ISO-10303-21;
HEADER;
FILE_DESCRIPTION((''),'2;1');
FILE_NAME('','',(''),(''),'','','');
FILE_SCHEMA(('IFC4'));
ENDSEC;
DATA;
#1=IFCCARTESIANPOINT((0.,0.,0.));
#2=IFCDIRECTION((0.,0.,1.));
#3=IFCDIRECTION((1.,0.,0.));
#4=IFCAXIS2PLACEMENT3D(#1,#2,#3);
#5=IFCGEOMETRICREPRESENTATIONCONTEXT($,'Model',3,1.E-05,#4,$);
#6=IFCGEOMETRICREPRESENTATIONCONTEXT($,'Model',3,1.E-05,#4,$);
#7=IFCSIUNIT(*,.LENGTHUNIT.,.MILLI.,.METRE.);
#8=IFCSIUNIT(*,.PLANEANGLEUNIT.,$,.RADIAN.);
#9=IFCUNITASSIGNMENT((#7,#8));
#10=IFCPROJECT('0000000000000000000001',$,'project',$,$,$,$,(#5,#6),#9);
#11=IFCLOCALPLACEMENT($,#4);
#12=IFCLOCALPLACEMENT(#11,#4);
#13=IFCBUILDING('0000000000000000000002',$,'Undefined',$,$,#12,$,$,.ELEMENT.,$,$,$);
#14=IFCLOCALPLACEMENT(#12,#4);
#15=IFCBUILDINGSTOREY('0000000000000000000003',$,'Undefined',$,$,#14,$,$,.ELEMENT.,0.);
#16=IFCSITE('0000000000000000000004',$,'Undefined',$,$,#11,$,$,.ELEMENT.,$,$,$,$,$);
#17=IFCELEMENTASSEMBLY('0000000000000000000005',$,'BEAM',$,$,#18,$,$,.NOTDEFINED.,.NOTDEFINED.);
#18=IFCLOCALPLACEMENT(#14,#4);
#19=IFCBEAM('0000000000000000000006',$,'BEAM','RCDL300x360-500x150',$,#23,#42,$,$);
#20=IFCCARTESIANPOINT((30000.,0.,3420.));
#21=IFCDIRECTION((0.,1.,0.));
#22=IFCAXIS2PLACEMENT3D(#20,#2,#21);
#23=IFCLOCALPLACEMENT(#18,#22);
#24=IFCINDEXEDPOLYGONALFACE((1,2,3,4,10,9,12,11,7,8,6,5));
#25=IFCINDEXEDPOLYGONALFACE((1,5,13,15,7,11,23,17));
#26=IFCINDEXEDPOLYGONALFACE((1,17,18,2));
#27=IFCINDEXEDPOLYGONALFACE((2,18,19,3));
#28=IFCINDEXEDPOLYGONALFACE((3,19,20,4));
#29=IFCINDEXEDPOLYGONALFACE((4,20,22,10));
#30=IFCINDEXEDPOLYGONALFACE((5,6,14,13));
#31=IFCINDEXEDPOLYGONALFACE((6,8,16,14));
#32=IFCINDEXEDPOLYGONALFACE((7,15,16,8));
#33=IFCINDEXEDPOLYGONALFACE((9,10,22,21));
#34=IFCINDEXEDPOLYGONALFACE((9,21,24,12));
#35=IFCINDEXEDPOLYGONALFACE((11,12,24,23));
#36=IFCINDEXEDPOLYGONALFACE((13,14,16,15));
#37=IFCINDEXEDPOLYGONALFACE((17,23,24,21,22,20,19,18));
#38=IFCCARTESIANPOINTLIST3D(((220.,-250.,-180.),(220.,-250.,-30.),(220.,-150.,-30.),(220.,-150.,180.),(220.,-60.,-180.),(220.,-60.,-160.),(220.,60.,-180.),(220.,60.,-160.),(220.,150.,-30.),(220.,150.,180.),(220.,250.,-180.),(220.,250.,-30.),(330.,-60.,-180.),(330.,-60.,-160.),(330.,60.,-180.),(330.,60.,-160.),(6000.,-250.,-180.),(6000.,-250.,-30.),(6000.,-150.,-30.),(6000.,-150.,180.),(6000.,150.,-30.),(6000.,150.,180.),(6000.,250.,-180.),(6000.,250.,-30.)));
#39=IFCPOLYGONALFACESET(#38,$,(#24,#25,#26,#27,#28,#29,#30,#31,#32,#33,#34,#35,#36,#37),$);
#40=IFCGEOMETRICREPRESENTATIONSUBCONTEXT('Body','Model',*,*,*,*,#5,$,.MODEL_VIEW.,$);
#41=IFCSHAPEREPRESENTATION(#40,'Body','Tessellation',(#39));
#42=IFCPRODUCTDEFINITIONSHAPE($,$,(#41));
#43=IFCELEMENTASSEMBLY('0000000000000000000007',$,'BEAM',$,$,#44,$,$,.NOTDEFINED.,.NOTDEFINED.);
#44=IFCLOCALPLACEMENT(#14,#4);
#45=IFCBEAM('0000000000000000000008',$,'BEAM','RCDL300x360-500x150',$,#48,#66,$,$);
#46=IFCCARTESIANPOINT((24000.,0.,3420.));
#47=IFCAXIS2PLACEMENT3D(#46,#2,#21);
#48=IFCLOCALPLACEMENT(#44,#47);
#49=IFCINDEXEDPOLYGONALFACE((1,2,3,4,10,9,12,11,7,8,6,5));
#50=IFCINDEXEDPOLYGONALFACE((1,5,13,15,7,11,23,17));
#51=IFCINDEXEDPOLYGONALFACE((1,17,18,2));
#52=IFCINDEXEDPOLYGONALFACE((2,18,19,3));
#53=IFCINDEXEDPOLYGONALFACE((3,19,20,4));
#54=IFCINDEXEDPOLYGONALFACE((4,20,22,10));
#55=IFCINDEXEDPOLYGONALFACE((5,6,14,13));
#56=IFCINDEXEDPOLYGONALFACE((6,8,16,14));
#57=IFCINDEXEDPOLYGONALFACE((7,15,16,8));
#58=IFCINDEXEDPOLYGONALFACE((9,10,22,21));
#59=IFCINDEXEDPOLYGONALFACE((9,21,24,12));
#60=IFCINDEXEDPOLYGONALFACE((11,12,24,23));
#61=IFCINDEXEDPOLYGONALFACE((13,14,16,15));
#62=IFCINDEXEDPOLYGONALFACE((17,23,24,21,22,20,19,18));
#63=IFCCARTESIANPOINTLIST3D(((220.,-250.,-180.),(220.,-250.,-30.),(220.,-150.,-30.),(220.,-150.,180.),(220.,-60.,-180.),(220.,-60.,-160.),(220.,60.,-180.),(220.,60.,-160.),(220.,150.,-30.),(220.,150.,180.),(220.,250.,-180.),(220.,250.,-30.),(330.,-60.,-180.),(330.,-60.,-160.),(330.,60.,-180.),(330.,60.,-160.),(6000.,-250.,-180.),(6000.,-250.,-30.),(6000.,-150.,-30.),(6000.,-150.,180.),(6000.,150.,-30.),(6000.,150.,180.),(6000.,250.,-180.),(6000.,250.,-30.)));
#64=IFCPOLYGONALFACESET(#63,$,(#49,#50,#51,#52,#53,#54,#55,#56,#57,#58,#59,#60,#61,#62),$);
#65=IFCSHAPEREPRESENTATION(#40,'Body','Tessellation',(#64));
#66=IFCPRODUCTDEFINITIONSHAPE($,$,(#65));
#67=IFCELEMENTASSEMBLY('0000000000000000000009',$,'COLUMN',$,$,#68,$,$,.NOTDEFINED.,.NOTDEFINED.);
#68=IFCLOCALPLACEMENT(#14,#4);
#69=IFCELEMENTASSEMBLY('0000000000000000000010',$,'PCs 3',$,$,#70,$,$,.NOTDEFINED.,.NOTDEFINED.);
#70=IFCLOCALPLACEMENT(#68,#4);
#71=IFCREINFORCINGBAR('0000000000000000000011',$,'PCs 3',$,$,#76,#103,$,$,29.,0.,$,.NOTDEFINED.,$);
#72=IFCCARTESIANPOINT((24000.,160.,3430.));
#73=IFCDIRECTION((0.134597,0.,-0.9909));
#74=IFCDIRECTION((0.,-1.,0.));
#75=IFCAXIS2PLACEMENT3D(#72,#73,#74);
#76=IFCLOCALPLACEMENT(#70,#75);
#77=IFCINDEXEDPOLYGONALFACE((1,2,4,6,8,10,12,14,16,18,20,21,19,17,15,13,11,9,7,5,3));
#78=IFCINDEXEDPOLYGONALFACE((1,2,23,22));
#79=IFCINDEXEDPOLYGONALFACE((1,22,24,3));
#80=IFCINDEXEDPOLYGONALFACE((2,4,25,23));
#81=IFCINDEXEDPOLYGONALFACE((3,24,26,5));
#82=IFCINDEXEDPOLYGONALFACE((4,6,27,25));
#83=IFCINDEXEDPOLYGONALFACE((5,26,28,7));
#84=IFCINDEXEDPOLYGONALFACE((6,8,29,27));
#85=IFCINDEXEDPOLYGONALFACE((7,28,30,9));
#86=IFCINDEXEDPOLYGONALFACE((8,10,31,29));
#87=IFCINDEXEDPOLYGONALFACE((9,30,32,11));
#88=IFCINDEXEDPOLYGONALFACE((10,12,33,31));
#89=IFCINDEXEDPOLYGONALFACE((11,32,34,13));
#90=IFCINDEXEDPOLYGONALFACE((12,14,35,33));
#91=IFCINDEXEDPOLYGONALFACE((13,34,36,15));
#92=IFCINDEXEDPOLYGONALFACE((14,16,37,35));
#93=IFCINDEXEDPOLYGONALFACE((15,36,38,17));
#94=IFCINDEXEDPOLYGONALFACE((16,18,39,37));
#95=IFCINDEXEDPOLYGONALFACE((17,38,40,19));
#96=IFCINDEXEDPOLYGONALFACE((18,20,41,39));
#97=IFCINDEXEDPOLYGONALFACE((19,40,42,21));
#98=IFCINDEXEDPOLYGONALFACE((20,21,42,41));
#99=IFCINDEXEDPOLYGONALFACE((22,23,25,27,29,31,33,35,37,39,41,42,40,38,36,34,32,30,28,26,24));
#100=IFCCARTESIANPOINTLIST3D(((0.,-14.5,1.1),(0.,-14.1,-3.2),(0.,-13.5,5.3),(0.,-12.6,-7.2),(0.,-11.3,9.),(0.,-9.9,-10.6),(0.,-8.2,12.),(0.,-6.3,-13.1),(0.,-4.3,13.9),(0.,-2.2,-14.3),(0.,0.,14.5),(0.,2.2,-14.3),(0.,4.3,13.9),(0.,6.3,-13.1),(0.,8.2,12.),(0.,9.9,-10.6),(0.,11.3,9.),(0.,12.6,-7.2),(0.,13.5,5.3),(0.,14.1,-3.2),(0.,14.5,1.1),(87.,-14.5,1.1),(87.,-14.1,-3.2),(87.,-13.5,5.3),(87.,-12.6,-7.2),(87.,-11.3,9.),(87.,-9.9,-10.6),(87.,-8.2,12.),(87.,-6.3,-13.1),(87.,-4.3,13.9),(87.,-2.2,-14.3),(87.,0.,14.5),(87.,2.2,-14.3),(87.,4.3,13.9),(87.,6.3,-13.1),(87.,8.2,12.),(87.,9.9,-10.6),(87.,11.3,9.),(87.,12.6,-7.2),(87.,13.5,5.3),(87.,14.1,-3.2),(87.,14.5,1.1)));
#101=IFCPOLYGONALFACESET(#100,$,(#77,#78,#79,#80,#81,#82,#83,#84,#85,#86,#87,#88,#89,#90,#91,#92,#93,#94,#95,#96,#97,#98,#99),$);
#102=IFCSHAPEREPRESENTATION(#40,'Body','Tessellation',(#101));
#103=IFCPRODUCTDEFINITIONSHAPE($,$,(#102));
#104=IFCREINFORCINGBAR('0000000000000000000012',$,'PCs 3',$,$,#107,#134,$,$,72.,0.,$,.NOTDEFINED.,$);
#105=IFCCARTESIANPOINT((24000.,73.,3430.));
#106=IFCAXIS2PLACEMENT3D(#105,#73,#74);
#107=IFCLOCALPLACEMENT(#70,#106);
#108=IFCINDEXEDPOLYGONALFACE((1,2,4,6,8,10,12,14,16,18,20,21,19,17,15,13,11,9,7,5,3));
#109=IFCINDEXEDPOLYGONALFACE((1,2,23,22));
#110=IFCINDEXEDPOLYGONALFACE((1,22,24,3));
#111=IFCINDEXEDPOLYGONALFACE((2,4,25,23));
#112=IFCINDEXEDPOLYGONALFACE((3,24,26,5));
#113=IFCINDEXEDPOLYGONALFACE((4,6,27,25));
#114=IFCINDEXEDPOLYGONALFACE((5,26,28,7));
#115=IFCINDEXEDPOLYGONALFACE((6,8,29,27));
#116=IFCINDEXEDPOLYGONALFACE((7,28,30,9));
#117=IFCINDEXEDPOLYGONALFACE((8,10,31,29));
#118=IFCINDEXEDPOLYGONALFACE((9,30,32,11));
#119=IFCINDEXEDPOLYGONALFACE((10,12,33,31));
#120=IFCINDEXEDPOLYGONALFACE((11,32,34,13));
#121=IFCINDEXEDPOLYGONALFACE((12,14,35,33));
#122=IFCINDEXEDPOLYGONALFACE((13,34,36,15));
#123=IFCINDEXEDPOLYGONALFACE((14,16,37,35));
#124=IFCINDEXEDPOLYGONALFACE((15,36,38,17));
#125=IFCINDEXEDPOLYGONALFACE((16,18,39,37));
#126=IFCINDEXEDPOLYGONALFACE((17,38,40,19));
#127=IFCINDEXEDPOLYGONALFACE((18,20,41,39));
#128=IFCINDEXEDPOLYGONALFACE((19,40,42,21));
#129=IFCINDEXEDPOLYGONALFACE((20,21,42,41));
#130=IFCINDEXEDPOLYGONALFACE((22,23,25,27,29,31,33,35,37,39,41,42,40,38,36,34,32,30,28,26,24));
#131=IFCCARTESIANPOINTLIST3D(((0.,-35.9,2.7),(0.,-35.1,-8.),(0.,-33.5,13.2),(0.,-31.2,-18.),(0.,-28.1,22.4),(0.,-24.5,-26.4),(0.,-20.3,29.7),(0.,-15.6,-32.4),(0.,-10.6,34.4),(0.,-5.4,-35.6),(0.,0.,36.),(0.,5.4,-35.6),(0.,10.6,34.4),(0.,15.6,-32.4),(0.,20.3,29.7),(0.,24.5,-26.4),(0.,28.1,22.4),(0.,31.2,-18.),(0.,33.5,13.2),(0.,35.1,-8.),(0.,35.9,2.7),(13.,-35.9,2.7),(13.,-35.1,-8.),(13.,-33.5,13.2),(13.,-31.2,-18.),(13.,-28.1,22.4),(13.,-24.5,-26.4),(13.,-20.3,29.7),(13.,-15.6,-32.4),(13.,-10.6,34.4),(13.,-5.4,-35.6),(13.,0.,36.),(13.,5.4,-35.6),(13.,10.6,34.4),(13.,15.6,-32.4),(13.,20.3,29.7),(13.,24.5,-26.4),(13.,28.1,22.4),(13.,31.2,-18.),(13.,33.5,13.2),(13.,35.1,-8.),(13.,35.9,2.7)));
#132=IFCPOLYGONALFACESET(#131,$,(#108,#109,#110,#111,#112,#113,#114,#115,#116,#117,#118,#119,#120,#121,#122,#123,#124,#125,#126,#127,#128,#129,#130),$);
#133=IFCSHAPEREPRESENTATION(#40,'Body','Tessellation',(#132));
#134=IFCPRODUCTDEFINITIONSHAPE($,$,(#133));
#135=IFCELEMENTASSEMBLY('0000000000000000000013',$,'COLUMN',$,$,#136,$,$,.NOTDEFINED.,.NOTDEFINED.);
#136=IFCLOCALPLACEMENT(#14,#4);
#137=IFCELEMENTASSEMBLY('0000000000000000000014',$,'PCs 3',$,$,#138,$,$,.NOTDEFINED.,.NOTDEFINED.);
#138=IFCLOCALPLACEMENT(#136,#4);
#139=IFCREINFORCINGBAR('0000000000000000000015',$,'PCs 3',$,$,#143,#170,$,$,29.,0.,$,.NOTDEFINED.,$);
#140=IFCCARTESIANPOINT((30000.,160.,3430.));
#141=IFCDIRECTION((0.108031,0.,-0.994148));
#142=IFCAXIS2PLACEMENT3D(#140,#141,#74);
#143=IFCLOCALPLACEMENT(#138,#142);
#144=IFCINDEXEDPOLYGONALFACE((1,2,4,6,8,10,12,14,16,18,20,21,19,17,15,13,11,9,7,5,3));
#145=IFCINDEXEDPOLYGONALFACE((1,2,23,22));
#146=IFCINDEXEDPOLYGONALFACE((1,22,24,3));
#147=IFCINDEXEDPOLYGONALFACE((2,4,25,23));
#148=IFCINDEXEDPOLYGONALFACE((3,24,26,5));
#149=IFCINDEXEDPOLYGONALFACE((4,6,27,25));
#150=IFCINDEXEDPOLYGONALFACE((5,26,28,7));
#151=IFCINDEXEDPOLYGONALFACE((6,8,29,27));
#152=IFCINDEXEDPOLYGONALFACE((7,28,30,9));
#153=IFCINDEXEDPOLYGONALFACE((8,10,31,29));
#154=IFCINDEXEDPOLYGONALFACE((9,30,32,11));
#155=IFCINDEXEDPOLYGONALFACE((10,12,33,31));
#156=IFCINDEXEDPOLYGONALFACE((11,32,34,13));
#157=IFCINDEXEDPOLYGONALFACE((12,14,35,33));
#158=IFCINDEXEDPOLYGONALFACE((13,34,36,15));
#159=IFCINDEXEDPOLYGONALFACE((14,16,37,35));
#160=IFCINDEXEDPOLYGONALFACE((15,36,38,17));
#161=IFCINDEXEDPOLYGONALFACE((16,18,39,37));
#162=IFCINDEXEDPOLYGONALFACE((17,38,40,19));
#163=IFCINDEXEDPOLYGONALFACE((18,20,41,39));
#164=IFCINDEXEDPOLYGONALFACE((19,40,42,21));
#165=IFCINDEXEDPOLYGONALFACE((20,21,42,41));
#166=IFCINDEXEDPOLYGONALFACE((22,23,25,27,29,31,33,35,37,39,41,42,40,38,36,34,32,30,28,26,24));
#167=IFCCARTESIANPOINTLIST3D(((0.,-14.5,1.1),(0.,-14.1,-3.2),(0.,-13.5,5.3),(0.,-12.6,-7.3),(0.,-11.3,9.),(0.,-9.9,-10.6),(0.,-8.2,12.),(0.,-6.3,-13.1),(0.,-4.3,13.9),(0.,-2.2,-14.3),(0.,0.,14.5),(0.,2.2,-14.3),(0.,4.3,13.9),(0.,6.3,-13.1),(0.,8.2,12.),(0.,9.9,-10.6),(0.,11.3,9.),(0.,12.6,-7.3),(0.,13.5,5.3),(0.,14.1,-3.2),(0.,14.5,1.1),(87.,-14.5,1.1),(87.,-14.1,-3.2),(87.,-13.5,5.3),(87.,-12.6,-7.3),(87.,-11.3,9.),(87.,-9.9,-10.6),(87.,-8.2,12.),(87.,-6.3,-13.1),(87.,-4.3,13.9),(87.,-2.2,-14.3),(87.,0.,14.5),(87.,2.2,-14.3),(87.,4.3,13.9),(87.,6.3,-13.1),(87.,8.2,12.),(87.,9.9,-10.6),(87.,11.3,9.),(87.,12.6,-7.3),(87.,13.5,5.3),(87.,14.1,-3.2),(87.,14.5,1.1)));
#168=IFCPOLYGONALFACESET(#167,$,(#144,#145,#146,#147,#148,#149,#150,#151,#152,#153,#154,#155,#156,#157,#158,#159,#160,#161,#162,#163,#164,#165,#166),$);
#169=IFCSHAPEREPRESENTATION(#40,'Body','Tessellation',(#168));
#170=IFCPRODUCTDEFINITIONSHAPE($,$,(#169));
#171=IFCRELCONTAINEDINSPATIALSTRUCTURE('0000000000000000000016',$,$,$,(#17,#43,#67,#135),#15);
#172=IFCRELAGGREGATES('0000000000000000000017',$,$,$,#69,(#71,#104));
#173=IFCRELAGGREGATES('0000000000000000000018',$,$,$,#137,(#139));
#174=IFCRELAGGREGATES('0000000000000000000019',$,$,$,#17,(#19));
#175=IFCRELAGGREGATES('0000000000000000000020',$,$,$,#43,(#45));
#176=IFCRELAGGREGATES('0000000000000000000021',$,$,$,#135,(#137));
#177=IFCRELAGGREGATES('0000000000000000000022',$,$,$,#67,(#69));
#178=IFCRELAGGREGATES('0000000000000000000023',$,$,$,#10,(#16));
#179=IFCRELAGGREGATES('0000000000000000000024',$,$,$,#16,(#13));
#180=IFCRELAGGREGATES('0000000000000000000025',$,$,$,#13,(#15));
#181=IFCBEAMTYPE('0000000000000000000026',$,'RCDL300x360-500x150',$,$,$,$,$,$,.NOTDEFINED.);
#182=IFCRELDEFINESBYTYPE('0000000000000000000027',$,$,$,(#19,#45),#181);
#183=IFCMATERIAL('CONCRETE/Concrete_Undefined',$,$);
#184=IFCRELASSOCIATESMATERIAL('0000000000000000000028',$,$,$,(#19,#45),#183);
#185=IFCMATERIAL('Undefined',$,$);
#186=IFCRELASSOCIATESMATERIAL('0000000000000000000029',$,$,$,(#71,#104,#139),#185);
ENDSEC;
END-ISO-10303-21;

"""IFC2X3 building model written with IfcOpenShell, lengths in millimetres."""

from ifc_helpers import new_model, entity, si_unit, frame, origin_with_axes, origin_2d_with_axis, place, context, subcontext, project, spatial, polyline, rectangle, outline, extrude, clip, halfspace, source, transform, mapped, material, type_object, element, aggregate, save


model = new_model("IFC2X3")

# Units and contexts
model_context_1 = context("Model", 3, precision=1e-05, world=origin_with_axes())
model_context_2 = context("Model", 3, precision=1e-05, world=origin_with_axes())
body_context = subcontext(model_context_1, "Body", "Model", "MODEL_VIEW")
ifc_project = project(units=[si_unit("LENGTHUNIT", "METRE", prefix="MILLI"), si_unit("PLANEANGLEUNIT", "RADIAN")], contexts=[model_context_1, model_context_2])

# Site, building, storey
site_placement = place(None, origin_with_axes())
site = spatial("IfcSite", under=ifc_project, at=site_placement, Name="Undefined", CompositionType="ELEMENT")
building_placement = place(site_placement, origin_with_axes())
building = spatial("IfcBuilding", under=site, at=building_placement, Name="Undefined", CompositionType="ELEMENT")
storey_placement = place(building_placement, origin_with_axes())
storey = spatial("IfcBuildingStorey", under=building, at=storey_placement, Name="Undefined", CompositionType="ELEMENT", Elevation=0.0)

# Element assemblies, beams, openings
assembly_1_placement = place(storey_placement, origin_with_axes())
assembly_1 = element("IfcElementAssembly", 1, at=assembly_1_placement, inside=storey, Name="BEAM", AssemblyPlace="NOTDEFINED", PredefinedType="NOTDEFINED")
ifc_material_1 = material(Name="CONCRETE/Concrete_Undefined")
beam_type = type_object("IfcBeamType", Name="RCDL300x360-500x150", PredefinedType="NOTDEFINED")
beam_1_placement = place(assembly_1_placement, frame((30000.0, 0.0, 3420.0), z_axis=(0.0, 0.0, 1.0), x_axis=(0.0, 1.0, 0.0)))
beam_1 = element("IfcBeam", 2, at=beam_1_placement, type_object=beam_type, material=ifc_material_1, Name="BEAM", Description="RCDL300x360-500x150", context=body_context, shape_type="Clipping", body=[
    clip(extrude(outline(polyline([(150.0, 180.0), (150.0, -30.0), (250.0, -30.0), (250.0, -180.0), (-250.0, -180.0), (-250.0, -30.0), (-150.0, -30.0), (-150.0, 180.0), (150.0, 180.0)])), frame((6000.0, 0.0, 0.0), z_axis=(-1.0, 0.0, 0.0), x_axis=(0.0, -1.0, 0.0)), (0.0, 0.0, 1.0), 6000.0), halfspace(frame((220.0, 0.0, -160.0), z_axis=(1.0, 0.0, 0.0), x_axis=(0.0, 0.0, 1.0)), True)),
])
opening_1_placement = place(assembly_1_placement, frame((30000.0, 0.0, 3420.0), z_axis=(0.0, 0.0, 1.0), x_axis=(0.0, 1.0, 0.0)))
element("IfcOpeningElement", 3, at=opening_1_placement, cuts=beam_1, ObjectType="Recess", context=body_context, shape_type="SweptSolid", body=[
    extrude(rectangle(XDim=25.0, YDim=120.0, at=origin_2d_with_axis()), frame((330.0, 0.0, -172.5), z_axis=(-1.0, 0.0, 0.0), x_axis=(0.0, 0.0, -1.0)), (0.0, 0.0, 1.0), 115.0),
])
assembly_2_placement = place(storey_placement, origin_with_axes())
assembly_2 = element("IfcElementAssembly", 4, at=assembly_2_placement, inside=storey, Name="BEAM", AssemblyPlace="NOTDEFINED", PredefinedType="NOTDEFINED")
beam_2_placement = place(assembly_2_placement, frame((24000.0, 0.0, 3420.0), z_axis=(0.0, 0.0, 1.0), x_axis=(0.0, 1.0, 0.0)))
beam_2 = element("IfcBeam", 5, at=beam_2_placement, type_object=beam_type, material=ifc_material_1, Name="BEAM", Description="RCDL300x360-500x150", context=body_context, shape_type="Clipping", body=[
    clip(extrude(outline(polyline([(150.0, 180.0), (150.0, -30.0), (250.0, -30.0), (250.0, -180.0), (-250.0, -180.0), (-250.0, -30.0), (-150.0, -30.0), (-150.0, 180.0), (150.0, 180.0)])), frame((6000.0, 0.0, 0.0), z_axis=(-1.0, 0.0, 0.0), x_axis=(0.0, -1.0, 0.0)), (0.0, 0.0, 1.0), 6000.0), halfspace(frame((220.0, 0.0, -160.0), z_axis=(1.0, 0.0, 0.0), x_axis=(0.0, 0.0, 1.0)), True)),
])
opening_2_placement = place(assembly_2_placement, frame((24000.0, 0.0, 3420.0), z_axis=(0.0, 0.0, 1.0), x_axis=(0.0, 1.0, 0.0)))
element("IfcOpeningElement", 6, at=opening_2_placement, cuts=beam_2, ObjectType="Recess", context=body_context, shape_type="SweptSolid", body=[
    extrude(rectangle(XDim=25.0, YDim=120.0, at=origin_2d_with_axis()), frame((330.0, 0.0, -172.5), z_axis=(-1.0, 0.0, 0.0), x_axis=(0.0, 0.0, -1.0)), (0.0, 0.0, 1.0), 115.0),
])

# Element assemblies
assembly_3_placement = place(storey_placement, origin_with_axes())
assembly_3 = element("IfcElementAssembly", 7, at=assembly_3_placement, inside=storey, Name="COLUMN", AssemblyPlace="NOTDEFINED", PredefinedType="NOTDEFINED")
assembly_4_placement = place(assembly_3_placement, origin_with_axes())
assembly_4 = element("IfcElementAssembly", 8, at=assembly_4_placement, Name="PCs 3", AssemblyPlace="NOTDEFINED", PredefinedType="NOTDEFINED")

# Shared definitions
ifc_material_2 = material(Name="Undefined")

# Reinforcing bars
shared_shape_1 = source(origin_with_axes(), body_context, "Body", "AdvancedSweptSolid", [
    entity("IfcSweptDiskSolid", entity("IfcTrimmedCurve", entity("IfcLine", entity("IfcCartesianPoint", [0.0, 0.0, 0.0]), entity("IfcVector", entity("IfcDirection", [1.0, 0.0, 0.0]), 1.0)), [entity("IfcParameterValue", 0.0)], [entity("IfcParameterValue", 87.0)], True, "PARAMETER"), 14.5, None, 0.0, 87.0),
])
reinforcing_bar_1_placement = place(assembly_4_placement, frame((24000.0, 160.0, 3430.0), z_axis=(0.134597, 0.0, -0.9909), x_axis=(0.0, -1.0, 0.0)))
reinforcing_bar_1 = element("IfcReinforcingBar", 9, at=reinforcing_bar_1_placement, material=ifc_material_2, Name="PCs 3", BarRole="NOTDEFINED", CrossSectionArea=0.0, NominalDiameter=29.0, context=body_context, shape_type="MappedRepresentation", body=[
    mapped(shared_shape_1, transform((0.0, 0.0, 0.0))),
])
shared_shape_2 = source(origin_with_axes(), body_context, "Body", "AdvancedSweptSolid", [
    entity("IfcSweptDiskSolid", entity("IfcTrimmedCurve", entity("IfcLine", entity("IfcCartesianPoint", [0.0, 0.0, 0.0]), entity("IfcVector", entity("IfcDirection", [1.0, 0.0, 0.0]), 1.0)), [entity("IfcParameterValue", 0.0)], [entity("IfcParameterValue", 13.0)], True, "PARAMETER"), 36.0, None, 0.0, 13.0),
])
reinforcing_bar_2_placement = place(assembly_4_placement, frame((24000.0, 73.0, 3430.0), z_axis=(0.134597, 0.0, -0.9909), x_axis=(0.0, -1.0, 0.0)))
reinforcing_bar_2 = element("IfcReinforcingBar", 10, at=reinforcing_bar_2_placement, material=ifc_material_2, Name="PCs 3", BarRole="NOTDEFINED", CrossSectionArea=0.0, NominalDiameter=72.0, context=body_context, shape_type="MappedRepresentation", body=[
    mapped(shared_shape_2, transform((0.0, 0.0, 0.0))),
])
aggregate(assembly_4, [reinforcing_bar_1, reinforcing_bar_2])

# Element assemblies, reinforcing bar
assembly_5_placement = place(storey_placement, origin_with_axes())
assembly_5 = element("IfcElementAssembly", 11, at=assembly_5_placement, inside=storey, Name="COLUMN", AssemblyPlace="NOTDEFINED", PredefinedType="NOTDEFINED")
assembly_6_placement = place(assembly_5_placement, origin_with_axes())
assembly_6 = element("IfcElementAssembly", 12, at=assembly_6_placement, Name="PCs 3", AssemblyPlace="NOTDEFINED", PredefinedType="NOTDEFINED")
shared_shape_3 = source(origin_with_axes(), body_context, "Body", "AdvancedSweptSolid", [
    entity("IfcSweptDiskSolid", entity("IfcTrimmedCurve", entity("IfcLine", entity("IfcCartesianPoint", [0.0, 0.0, 0.0]), entity("IfcVector", entity("IfcDirection", [1.0, 0.0, 0.0]), 1.0)), [entity("IfcParameterValue", 0.0)], [entity("IfcParameterValue", 87.0)], True, "PARAMETER"), 14.5, None, 0.0, 87.0),
])
reinforcing_bar_3_placement = place(assembly_6_placement, frame((30000.0, 160.0, 3430.0), z_axis=(0.108031, 0.0, -0.994148), x_axis=(0.0, -1.0, 0.0)))
reinforcing_bar_3 = element("IfcReinforcingBar", 13, at=reinforcing_bar_3_placement, material=ifc_material_2, Name="PCs 3", BarRole="NOTDEFINED", CrossSectionArea=0.0, NominalDiameter=29.0, context=body_context, shape_type="MappedRepresentation", body=[
    mapped(shared_shape_3, transform((0.0, 0.0, 0.0))),
])
aggregate(assembly_6, [reinforcing_bar_3])

aggregate(assembly_1, [beam_1])
aggregate(assembly_2, [beam_2])
aggregate(assembly_5, [assembly_6])
aggregate(assembly_3, [assembly_4])

save(model, "model.ifc")
